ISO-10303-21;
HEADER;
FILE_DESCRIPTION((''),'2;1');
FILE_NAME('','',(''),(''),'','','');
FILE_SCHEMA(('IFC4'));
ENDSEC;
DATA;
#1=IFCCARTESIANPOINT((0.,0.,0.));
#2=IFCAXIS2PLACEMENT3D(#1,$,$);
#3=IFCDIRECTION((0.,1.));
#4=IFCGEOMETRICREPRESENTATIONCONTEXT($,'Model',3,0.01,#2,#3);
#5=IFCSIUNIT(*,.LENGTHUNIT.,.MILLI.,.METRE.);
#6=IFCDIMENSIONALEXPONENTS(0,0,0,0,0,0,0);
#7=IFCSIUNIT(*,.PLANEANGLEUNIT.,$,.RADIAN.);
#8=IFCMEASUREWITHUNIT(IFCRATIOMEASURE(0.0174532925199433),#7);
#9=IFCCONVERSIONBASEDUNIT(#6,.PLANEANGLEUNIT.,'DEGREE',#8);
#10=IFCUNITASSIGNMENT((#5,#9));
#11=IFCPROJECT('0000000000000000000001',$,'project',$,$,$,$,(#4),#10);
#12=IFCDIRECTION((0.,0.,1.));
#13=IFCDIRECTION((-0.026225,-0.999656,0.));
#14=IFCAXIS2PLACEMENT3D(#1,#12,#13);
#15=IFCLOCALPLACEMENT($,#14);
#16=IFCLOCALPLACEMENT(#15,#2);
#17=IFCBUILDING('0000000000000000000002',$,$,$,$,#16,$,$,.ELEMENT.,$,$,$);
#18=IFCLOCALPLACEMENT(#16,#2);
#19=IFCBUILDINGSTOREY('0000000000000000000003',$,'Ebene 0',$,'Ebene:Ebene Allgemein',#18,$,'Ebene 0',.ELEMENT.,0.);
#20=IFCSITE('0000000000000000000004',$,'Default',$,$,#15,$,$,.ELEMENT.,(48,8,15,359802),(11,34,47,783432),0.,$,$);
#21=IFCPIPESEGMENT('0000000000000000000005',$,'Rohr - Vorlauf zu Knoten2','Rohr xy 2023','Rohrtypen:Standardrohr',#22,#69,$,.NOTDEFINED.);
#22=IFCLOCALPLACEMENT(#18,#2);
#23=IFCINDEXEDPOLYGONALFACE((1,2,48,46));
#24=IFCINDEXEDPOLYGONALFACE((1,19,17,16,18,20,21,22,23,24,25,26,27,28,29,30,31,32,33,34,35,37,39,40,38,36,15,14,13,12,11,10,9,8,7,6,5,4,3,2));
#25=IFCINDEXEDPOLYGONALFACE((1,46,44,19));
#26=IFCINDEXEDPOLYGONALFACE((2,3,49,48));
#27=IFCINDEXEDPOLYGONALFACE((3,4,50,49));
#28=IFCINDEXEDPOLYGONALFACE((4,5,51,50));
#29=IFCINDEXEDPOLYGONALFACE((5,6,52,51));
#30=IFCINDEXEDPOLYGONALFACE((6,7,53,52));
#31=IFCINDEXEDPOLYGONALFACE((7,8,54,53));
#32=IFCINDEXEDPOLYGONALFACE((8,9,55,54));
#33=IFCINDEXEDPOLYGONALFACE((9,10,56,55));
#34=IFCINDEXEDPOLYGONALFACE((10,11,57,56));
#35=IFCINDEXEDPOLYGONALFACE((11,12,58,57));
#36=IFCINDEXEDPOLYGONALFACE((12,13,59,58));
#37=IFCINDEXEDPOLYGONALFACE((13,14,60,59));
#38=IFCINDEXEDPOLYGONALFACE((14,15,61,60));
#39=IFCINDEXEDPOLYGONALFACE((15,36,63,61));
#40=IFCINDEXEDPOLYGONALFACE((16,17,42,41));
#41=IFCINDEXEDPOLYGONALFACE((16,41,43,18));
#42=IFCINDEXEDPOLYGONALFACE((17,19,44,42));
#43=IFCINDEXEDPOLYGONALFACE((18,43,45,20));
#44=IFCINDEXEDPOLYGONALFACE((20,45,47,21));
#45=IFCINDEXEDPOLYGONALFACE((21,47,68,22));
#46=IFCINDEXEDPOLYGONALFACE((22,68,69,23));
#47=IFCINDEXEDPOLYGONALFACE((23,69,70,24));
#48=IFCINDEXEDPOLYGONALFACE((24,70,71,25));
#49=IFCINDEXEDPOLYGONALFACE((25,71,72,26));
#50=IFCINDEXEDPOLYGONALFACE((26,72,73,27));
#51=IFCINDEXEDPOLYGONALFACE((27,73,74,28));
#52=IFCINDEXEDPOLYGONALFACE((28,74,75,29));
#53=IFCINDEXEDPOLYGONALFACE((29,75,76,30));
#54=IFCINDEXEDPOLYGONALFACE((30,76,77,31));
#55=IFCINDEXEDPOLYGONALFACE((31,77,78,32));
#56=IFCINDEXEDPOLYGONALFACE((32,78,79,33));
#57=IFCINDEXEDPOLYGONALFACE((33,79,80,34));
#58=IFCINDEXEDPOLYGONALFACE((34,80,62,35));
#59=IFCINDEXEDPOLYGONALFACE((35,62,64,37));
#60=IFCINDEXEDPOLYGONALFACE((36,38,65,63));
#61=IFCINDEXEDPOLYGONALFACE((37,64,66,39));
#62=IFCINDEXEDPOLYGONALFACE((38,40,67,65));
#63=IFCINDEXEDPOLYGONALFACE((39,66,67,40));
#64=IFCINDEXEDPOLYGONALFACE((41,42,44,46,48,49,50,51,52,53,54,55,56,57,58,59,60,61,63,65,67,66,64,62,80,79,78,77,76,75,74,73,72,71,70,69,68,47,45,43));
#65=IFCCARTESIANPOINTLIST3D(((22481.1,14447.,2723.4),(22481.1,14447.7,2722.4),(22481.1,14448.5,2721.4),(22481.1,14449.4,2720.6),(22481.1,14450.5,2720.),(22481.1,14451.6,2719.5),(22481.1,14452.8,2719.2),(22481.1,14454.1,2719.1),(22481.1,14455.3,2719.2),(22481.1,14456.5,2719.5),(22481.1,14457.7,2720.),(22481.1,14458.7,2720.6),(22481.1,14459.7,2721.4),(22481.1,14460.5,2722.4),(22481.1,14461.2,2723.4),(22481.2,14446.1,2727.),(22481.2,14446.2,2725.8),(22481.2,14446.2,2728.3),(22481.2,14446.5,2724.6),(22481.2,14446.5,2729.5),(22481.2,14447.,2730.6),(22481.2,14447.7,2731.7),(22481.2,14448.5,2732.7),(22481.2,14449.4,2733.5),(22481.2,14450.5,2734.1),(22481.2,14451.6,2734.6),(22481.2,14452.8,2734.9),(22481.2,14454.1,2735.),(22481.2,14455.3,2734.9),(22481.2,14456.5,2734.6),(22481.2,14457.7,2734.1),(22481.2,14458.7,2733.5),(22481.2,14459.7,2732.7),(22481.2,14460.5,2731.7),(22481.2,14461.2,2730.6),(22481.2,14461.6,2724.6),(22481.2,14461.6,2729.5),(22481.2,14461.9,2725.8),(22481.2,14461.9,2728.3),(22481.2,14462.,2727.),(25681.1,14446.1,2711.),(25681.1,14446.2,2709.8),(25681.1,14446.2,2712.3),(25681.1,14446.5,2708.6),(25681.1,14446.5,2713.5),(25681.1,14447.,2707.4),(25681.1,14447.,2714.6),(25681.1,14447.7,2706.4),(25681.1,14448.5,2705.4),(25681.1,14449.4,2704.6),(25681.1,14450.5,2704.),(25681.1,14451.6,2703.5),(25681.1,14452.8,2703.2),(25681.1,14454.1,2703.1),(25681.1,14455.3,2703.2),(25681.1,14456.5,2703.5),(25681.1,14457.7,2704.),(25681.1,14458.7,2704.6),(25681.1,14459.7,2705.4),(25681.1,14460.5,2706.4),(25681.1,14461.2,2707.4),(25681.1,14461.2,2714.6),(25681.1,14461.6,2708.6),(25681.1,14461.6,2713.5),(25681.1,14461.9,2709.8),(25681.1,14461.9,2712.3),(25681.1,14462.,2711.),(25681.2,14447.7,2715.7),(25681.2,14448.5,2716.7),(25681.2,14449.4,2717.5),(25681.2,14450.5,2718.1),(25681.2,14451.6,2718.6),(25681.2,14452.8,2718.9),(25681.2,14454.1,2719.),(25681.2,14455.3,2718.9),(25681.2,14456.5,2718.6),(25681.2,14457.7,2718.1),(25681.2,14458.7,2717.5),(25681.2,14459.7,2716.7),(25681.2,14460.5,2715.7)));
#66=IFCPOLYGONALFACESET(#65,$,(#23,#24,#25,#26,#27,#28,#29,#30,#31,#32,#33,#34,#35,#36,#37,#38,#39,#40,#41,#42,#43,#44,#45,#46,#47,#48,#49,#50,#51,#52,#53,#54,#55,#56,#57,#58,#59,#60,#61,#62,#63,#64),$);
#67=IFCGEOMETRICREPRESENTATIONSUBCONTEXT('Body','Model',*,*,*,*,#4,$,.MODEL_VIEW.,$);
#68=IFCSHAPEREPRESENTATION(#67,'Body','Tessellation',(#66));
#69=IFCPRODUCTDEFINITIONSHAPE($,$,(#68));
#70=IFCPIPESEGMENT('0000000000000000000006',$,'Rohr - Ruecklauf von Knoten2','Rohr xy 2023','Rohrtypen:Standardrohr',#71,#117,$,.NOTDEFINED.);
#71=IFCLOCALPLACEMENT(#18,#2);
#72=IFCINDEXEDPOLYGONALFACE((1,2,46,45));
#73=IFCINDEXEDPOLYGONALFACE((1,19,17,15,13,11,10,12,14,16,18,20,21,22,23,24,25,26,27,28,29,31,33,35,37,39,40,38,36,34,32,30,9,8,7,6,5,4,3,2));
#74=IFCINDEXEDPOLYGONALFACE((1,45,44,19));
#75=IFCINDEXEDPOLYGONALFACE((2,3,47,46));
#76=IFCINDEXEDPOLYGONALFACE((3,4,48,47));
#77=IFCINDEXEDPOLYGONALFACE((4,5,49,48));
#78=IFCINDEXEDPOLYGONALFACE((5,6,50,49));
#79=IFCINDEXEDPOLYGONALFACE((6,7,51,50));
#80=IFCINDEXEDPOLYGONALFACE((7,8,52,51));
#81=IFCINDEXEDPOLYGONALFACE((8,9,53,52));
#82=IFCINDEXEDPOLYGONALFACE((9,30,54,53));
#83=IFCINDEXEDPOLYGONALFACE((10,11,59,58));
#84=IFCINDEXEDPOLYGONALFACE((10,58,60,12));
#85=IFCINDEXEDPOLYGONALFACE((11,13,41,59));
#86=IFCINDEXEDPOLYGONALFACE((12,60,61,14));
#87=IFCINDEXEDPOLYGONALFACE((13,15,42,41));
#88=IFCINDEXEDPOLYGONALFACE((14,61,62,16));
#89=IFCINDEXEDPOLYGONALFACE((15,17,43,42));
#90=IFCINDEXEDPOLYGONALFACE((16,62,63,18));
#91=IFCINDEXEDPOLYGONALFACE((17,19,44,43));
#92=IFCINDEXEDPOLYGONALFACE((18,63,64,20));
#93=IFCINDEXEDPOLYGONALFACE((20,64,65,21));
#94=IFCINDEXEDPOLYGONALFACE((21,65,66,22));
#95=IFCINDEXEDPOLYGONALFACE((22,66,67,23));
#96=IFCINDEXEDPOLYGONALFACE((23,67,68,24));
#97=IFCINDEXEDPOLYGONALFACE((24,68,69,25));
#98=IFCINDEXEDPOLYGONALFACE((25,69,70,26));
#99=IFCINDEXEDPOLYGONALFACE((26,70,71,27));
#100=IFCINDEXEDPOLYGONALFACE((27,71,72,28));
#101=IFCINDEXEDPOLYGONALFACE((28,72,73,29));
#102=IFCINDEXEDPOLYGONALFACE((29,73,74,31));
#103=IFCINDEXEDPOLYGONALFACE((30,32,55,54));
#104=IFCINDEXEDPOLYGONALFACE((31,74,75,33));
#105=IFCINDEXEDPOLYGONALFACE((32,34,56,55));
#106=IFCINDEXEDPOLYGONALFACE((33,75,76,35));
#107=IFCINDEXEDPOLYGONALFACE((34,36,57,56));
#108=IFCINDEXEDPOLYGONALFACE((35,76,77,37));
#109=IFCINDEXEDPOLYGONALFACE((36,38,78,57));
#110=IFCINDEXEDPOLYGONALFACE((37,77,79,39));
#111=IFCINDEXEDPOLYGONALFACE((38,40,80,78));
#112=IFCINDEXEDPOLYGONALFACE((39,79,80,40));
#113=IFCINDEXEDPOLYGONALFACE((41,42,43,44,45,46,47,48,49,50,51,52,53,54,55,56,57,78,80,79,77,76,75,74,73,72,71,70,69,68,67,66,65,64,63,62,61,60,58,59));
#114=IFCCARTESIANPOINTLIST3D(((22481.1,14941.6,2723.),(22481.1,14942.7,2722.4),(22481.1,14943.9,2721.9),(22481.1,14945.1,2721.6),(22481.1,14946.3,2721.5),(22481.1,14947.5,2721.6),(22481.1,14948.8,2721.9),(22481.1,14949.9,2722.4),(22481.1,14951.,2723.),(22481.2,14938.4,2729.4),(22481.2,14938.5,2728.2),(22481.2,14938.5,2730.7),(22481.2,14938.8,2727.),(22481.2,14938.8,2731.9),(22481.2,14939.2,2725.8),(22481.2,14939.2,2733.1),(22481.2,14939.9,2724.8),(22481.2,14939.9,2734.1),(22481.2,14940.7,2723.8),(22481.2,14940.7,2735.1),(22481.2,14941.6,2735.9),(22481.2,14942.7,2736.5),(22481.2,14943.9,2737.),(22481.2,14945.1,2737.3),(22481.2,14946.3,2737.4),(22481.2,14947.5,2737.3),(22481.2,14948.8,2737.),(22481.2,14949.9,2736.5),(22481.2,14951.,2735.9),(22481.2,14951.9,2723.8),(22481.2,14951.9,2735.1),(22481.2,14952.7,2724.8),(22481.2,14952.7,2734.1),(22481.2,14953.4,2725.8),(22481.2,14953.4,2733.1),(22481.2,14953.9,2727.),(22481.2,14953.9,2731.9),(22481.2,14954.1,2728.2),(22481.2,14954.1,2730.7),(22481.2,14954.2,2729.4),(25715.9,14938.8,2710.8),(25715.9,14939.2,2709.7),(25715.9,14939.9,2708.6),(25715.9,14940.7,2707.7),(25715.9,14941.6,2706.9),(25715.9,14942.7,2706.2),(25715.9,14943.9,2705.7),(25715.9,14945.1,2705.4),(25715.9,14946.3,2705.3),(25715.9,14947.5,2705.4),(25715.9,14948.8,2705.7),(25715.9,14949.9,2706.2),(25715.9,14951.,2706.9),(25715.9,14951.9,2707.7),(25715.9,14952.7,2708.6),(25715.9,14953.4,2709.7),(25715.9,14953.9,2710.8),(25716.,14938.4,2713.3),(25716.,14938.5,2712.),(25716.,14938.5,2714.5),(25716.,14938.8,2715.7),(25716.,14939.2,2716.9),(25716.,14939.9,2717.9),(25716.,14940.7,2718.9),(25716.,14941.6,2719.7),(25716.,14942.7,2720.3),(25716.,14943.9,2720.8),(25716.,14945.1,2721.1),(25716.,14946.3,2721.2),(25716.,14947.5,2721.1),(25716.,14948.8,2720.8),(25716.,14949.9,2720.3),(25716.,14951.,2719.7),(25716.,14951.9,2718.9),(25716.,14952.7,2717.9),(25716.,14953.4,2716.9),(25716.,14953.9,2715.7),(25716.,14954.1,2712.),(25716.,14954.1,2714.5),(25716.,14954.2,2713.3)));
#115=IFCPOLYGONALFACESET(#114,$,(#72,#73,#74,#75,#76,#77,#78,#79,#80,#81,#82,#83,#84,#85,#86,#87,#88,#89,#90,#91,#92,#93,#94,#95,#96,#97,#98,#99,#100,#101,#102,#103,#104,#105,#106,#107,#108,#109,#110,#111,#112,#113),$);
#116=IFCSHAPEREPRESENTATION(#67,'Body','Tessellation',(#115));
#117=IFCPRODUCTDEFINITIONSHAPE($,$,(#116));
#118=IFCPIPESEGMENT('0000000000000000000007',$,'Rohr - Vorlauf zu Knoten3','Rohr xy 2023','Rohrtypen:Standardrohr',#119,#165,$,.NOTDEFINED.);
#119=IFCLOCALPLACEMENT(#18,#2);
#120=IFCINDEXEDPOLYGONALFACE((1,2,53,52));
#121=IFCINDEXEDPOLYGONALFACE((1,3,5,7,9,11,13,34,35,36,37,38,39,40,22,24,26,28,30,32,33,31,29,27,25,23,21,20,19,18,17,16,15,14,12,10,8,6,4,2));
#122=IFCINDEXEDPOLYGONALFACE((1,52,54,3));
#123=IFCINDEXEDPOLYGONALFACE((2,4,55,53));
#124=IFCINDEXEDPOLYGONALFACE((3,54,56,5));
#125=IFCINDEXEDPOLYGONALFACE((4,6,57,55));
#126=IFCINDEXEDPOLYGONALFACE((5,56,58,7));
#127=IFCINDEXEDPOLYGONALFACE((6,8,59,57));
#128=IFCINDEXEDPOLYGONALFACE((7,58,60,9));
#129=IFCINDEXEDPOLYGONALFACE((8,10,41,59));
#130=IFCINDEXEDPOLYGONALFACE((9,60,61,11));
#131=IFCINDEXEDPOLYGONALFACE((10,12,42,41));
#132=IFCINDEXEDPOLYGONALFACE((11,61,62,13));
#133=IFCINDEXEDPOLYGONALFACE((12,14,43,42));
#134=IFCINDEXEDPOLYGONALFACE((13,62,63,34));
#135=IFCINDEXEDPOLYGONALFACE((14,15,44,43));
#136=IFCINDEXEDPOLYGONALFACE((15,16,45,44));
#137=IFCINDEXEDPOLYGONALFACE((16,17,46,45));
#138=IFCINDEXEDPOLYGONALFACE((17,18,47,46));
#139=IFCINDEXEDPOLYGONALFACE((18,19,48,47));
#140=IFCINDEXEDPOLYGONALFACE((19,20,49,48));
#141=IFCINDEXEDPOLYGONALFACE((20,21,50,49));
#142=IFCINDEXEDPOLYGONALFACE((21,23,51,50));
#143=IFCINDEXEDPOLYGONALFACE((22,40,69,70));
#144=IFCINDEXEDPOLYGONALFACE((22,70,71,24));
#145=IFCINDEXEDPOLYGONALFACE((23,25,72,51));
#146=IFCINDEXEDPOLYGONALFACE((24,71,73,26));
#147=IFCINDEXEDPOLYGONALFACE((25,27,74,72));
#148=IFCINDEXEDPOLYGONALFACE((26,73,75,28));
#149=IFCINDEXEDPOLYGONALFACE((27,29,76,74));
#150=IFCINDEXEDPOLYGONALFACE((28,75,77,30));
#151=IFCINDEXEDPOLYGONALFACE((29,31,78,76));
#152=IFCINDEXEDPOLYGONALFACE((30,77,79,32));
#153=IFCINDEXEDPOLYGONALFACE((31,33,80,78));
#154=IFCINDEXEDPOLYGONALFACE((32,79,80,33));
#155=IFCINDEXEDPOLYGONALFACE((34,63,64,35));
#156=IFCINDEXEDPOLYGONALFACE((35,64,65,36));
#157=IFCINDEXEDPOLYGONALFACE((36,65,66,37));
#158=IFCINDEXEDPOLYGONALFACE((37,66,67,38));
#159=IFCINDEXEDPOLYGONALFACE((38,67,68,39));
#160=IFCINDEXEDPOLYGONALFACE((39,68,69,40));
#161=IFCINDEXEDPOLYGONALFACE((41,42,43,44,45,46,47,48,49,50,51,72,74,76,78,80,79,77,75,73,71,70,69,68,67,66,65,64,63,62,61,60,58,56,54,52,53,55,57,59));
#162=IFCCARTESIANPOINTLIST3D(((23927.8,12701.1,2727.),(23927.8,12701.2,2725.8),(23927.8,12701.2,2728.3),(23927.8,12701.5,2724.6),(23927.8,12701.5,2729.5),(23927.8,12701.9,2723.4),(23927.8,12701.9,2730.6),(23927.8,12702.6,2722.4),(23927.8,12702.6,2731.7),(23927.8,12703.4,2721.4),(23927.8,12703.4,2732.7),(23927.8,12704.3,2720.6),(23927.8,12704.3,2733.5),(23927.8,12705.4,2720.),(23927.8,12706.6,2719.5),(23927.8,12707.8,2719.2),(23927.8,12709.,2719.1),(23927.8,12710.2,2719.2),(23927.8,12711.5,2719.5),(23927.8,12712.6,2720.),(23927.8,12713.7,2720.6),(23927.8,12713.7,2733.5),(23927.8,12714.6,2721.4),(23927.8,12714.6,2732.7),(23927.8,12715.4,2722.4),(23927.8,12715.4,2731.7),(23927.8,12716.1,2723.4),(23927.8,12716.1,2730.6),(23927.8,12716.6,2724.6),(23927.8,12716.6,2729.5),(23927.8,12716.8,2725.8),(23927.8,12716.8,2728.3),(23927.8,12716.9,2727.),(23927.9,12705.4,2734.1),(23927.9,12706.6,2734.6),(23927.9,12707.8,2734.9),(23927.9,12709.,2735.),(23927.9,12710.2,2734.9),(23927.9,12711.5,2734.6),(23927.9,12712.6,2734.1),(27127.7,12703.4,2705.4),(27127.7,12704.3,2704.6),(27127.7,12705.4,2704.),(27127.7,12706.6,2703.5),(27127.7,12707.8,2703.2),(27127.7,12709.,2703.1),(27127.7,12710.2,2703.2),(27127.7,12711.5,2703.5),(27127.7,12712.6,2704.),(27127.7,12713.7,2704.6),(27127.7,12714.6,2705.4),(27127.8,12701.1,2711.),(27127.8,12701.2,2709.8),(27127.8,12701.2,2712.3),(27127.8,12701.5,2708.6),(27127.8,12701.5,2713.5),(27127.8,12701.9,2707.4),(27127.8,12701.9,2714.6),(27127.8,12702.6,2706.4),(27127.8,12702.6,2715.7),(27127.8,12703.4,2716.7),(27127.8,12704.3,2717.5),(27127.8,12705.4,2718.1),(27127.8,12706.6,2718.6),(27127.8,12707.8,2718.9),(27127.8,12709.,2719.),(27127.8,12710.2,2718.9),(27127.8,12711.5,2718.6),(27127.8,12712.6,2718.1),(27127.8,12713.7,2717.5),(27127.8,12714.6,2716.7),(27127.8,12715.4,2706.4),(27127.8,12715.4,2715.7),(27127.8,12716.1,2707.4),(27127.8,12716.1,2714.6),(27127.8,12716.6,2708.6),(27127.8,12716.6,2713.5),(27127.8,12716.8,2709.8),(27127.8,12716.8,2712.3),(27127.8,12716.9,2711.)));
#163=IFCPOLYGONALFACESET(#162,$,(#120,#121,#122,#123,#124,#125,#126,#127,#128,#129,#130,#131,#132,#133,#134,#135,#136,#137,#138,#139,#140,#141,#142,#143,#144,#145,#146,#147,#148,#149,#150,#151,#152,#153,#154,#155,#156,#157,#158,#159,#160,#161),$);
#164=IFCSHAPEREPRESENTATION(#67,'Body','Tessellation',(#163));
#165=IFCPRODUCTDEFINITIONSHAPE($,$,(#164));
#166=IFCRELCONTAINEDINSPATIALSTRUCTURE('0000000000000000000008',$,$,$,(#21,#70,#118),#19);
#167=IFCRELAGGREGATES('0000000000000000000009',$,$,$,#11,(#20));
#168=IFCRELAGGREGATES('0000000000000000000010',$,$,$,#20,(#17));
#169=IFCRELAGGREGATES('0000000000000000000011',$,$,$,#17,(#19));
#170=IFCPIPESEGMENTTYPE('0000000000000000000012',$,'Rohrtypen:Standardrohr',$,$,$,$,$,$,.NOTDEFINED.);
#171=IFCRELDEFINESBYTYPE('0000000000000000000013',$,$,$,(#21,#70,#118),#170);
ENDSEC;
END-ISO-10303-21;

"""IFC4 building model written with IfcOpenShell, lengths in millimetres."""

from ifc_helpers import new_model, entity, si_unit, converted_unit, direction, frame, origin, place, context, subcontext, project, spatial, indexed_curve, outline, extrude, type_object, element, save


model = new_model("IFC4")

# Units and contexts
model_context = context("Model", 3, precision=0.01, world=origin(), true_north=direction((0.0, 1.0)))
body_context = subcontext(model_context, "Body", "Model", "MODEL_VIEW")
ifc_project = project(units=[si_unit("LENGTHUNIT", "METRE", prefix="MILLI"), converted_unit("PLANEANGLEUNIT", "DEGREE", entity("IfcRatioMeasure", 0.0174532925199433), si_unit("PLANEANGLEUNIT", "RADIAN"), dimensions=[0, 0, 0, 0, 0, 0, 0])], contexts=[model_context])

# Site, building, storey
site_placement = place(None, frame((0.0, 0.0, 0.0), z_axis=(0.0, 0.0, 1.0), x_axis=(-0.026225, -0.999656, 0.0)))
site = spatial("IfcSite", under=ifc_project, at=site_placement, Name="Default", CompositionType="ELEMENT", RefLatitude=(48, 8, 15, 359802), RefLongitude=(11, 34, 47, 783432), RefElevation=0.0)
building_placement = place(site_placement, origin())
building = spatial("IfcBuilding", under=site, at=building_placement, CompositionType="ELEMENT")
storey_placement = place(building_placement, origin())
storey = spatial("IfcBuildingStorey", under=building, at=storey_placement, Name="Ebene 0", ObjectType="Ebene:Ebene Allgemein", LongName="Ebene 0", CompositionType="ELEMENT", Elevation=0.0)

# Pipe segments
pipe_segment_type = type_object("IfcPipeSegmentType", Name="Rohrtypen:Standardrohr", PredefinedType="NOTDEFINED")
pipe_segment_1_placement = place(storey_placement, origin())
element("IfcPipeSegment", 1, at=pipe_segment_1_placement, inside=storey, type_object=pipe_segment_type, Name="Rohr - Vorlauf zu Knoten2", Description="Rohr xy 2023", ObjectType="Rohrtypen:Standardrohr", PredefinedType="NOTDEFINED", context=body_context, shape_type="SweptSolid", body=[
    extrude(outline(indexed_curve([(7.9, 0.0), (7.8, 1.2), (7.6, 2.5), (7.1, 3.6), (6.4, 4.7), (5.6, 5.6), (4.7, 6.4), (3.6, 7.1), (2.5, 7.6), (1.2, 7.8), (0.0, 7.9), (-1.2, 7.8), (-2.5, 7.6), (-3.6, 7.1), (-4.7, 6.4), (-5.6, 5.6), (-6.4, 4.7), (-7.1, 3.6), (-7.6, 2.5), (-7.8, 1.2), (-7.9, 0.0), (-7.8, -1.2), (-7.6, -2.5), (-7.1, -3.6), (-6.4, -4.7), (-5.6, -5.6), (-4.7, -6.4), (-3.6, -7.1), (-2.5, -7.6), (-1.2, -7.8), (0.0, -7.9), (1.2, -7.8), (2.5, -7.6), (3.6, -7.1), (4.7, -6.4), (5.6, -5.6), (6.4, -4.7), (7.1, -3.6), (7.6, -2.5), (7.8, -1.2), (7.9, 0.0)], self_intersect=False)), frame((25681.1, 14454.1, 2711.0), z_axis=(-0.999988, 0.0, 0.005), x_axis=(0.0, 1.0, 0.0)), (0.0, 0.0, 1.0), 3200.0),
])
pipe_segment_2_placement = place(storey_placement, origin())
element("IfcPipeSegment", 2, at=pipe_segment_2_placement, inside=storey, type_object=pipe_segment_type, Name="Rohr - Ruecklauf von Knoten2", Description="Rohr xy 2023", ObjectType="Rohrtypen:Standardrohr", PredefinedType="NOTDEFINED", context=body_context, shape_type="SweptSolid", body=[
    extrude(outline(indexed_curve([(7.9, 0.0), (7.8, 1.2), (7.6, 2.5), (7.1, 3.6), (6.4, 4.7), (5.6, 5.6), (4.7, 6.4), (3.6, 7.1), (2.5, 7.6), (1.2, 7.8), (0.0, 7.9), (-1.2, 7.8), (-2.5, 7.6), (-3.6, 7.1), (-4.7, 6.4), (-5.6, 5.6), (-6.4, 4.7), (-7.1, 3.6), (-7.6, 2.5), (-7.8, 1.2), (-7.9, 0.0), (-7.8, -1.2), (-7.6, -2.5), (-7.1, -3.6), (-6.4, -4.7), (-5.6, -5.6), (-4.7, -6.4), (-3.6, -7.1), (-2.5, -7.6), (-1.2, -7.8), (0.0, -7.9), (1.2, -7.8), (2.5, -7.6), (3.6, -7.1), (4.7, -6.4), (5.6, -5.6), (6.4, -4.7), (7.1, -3.6), (7.6, -2.5), (7.8, -1.2), (7.9, 0.0)], self_intersect=False)), frame((25716.0, 14946.3, 2713.3), z_axis=(-0.999988, 0.0, 0.005), x_axis=(0.0, 1.0, 0.0)), (0.0, 0.0, 1.0), 3234.8),
])
pipe_segment_3_placement = place(storey_placement, origin())
element("IfcPipeSegment", 3, at=pipe_segment_3_placement, inside=storey, type_object=pipe_segment_type, Name="Rohr - Vorlauf zu Knoten3", Description="Rohr xy 2023", ObjectType="Rohrtypen:Standardrohr", PredefinedType="NOTDEFINED", context=body_context, shape_type="SweptSolid", body=[
    extrude(outline(indexed_curve([(7.9, 0.0), (7.8, 1.2), (7.6, 2.5), (7.1, 3.6), (6.4, 4.7), (5.6, 5.6), (4.7, 6.4), (3.6, 7.1), (2.5, 7.6), (1.2, 7.8), (0.0, 7.9), (-1.2, 7.8), (-2.5, 7.6), (-3.6, 7.1), (-4.7, 6.4), (-5.6, 5.6), (-6.4, 4.7), (-7.1, 3.6), (-7.6, 2.5), (-7.8, 1.2), (-7.9, 0.0), (-7.8, -1.2), (-7.6, -2.5), (-7.1, -3.6), (-6.4, -4.7), (-5.6, -5.6), (-4.7, -6.4), (-3.6, -7.1), (-2.5, -7.6), (-1.2, -7.8), (0.0, -7.9), (1.2, -7.8), (2.5, -7.6), (3.6, -7.1), (4.7, -6.4), (5.6, -5.6), (6.4, -4.7), (7.1, -3.6), (7.6, -2.5), (7.8, -1.2), (7.9, 0.0)], self_intersect=False)), frame((27127.8, 12709.0, 2711.0), z_axis=(-0.999988, 0.0, 0.005), x_axis=(0.0, 1.0, 0.0)), (0.0, 0.0, 1.0), 3200.0),
])

save(model, "model.ifc")
